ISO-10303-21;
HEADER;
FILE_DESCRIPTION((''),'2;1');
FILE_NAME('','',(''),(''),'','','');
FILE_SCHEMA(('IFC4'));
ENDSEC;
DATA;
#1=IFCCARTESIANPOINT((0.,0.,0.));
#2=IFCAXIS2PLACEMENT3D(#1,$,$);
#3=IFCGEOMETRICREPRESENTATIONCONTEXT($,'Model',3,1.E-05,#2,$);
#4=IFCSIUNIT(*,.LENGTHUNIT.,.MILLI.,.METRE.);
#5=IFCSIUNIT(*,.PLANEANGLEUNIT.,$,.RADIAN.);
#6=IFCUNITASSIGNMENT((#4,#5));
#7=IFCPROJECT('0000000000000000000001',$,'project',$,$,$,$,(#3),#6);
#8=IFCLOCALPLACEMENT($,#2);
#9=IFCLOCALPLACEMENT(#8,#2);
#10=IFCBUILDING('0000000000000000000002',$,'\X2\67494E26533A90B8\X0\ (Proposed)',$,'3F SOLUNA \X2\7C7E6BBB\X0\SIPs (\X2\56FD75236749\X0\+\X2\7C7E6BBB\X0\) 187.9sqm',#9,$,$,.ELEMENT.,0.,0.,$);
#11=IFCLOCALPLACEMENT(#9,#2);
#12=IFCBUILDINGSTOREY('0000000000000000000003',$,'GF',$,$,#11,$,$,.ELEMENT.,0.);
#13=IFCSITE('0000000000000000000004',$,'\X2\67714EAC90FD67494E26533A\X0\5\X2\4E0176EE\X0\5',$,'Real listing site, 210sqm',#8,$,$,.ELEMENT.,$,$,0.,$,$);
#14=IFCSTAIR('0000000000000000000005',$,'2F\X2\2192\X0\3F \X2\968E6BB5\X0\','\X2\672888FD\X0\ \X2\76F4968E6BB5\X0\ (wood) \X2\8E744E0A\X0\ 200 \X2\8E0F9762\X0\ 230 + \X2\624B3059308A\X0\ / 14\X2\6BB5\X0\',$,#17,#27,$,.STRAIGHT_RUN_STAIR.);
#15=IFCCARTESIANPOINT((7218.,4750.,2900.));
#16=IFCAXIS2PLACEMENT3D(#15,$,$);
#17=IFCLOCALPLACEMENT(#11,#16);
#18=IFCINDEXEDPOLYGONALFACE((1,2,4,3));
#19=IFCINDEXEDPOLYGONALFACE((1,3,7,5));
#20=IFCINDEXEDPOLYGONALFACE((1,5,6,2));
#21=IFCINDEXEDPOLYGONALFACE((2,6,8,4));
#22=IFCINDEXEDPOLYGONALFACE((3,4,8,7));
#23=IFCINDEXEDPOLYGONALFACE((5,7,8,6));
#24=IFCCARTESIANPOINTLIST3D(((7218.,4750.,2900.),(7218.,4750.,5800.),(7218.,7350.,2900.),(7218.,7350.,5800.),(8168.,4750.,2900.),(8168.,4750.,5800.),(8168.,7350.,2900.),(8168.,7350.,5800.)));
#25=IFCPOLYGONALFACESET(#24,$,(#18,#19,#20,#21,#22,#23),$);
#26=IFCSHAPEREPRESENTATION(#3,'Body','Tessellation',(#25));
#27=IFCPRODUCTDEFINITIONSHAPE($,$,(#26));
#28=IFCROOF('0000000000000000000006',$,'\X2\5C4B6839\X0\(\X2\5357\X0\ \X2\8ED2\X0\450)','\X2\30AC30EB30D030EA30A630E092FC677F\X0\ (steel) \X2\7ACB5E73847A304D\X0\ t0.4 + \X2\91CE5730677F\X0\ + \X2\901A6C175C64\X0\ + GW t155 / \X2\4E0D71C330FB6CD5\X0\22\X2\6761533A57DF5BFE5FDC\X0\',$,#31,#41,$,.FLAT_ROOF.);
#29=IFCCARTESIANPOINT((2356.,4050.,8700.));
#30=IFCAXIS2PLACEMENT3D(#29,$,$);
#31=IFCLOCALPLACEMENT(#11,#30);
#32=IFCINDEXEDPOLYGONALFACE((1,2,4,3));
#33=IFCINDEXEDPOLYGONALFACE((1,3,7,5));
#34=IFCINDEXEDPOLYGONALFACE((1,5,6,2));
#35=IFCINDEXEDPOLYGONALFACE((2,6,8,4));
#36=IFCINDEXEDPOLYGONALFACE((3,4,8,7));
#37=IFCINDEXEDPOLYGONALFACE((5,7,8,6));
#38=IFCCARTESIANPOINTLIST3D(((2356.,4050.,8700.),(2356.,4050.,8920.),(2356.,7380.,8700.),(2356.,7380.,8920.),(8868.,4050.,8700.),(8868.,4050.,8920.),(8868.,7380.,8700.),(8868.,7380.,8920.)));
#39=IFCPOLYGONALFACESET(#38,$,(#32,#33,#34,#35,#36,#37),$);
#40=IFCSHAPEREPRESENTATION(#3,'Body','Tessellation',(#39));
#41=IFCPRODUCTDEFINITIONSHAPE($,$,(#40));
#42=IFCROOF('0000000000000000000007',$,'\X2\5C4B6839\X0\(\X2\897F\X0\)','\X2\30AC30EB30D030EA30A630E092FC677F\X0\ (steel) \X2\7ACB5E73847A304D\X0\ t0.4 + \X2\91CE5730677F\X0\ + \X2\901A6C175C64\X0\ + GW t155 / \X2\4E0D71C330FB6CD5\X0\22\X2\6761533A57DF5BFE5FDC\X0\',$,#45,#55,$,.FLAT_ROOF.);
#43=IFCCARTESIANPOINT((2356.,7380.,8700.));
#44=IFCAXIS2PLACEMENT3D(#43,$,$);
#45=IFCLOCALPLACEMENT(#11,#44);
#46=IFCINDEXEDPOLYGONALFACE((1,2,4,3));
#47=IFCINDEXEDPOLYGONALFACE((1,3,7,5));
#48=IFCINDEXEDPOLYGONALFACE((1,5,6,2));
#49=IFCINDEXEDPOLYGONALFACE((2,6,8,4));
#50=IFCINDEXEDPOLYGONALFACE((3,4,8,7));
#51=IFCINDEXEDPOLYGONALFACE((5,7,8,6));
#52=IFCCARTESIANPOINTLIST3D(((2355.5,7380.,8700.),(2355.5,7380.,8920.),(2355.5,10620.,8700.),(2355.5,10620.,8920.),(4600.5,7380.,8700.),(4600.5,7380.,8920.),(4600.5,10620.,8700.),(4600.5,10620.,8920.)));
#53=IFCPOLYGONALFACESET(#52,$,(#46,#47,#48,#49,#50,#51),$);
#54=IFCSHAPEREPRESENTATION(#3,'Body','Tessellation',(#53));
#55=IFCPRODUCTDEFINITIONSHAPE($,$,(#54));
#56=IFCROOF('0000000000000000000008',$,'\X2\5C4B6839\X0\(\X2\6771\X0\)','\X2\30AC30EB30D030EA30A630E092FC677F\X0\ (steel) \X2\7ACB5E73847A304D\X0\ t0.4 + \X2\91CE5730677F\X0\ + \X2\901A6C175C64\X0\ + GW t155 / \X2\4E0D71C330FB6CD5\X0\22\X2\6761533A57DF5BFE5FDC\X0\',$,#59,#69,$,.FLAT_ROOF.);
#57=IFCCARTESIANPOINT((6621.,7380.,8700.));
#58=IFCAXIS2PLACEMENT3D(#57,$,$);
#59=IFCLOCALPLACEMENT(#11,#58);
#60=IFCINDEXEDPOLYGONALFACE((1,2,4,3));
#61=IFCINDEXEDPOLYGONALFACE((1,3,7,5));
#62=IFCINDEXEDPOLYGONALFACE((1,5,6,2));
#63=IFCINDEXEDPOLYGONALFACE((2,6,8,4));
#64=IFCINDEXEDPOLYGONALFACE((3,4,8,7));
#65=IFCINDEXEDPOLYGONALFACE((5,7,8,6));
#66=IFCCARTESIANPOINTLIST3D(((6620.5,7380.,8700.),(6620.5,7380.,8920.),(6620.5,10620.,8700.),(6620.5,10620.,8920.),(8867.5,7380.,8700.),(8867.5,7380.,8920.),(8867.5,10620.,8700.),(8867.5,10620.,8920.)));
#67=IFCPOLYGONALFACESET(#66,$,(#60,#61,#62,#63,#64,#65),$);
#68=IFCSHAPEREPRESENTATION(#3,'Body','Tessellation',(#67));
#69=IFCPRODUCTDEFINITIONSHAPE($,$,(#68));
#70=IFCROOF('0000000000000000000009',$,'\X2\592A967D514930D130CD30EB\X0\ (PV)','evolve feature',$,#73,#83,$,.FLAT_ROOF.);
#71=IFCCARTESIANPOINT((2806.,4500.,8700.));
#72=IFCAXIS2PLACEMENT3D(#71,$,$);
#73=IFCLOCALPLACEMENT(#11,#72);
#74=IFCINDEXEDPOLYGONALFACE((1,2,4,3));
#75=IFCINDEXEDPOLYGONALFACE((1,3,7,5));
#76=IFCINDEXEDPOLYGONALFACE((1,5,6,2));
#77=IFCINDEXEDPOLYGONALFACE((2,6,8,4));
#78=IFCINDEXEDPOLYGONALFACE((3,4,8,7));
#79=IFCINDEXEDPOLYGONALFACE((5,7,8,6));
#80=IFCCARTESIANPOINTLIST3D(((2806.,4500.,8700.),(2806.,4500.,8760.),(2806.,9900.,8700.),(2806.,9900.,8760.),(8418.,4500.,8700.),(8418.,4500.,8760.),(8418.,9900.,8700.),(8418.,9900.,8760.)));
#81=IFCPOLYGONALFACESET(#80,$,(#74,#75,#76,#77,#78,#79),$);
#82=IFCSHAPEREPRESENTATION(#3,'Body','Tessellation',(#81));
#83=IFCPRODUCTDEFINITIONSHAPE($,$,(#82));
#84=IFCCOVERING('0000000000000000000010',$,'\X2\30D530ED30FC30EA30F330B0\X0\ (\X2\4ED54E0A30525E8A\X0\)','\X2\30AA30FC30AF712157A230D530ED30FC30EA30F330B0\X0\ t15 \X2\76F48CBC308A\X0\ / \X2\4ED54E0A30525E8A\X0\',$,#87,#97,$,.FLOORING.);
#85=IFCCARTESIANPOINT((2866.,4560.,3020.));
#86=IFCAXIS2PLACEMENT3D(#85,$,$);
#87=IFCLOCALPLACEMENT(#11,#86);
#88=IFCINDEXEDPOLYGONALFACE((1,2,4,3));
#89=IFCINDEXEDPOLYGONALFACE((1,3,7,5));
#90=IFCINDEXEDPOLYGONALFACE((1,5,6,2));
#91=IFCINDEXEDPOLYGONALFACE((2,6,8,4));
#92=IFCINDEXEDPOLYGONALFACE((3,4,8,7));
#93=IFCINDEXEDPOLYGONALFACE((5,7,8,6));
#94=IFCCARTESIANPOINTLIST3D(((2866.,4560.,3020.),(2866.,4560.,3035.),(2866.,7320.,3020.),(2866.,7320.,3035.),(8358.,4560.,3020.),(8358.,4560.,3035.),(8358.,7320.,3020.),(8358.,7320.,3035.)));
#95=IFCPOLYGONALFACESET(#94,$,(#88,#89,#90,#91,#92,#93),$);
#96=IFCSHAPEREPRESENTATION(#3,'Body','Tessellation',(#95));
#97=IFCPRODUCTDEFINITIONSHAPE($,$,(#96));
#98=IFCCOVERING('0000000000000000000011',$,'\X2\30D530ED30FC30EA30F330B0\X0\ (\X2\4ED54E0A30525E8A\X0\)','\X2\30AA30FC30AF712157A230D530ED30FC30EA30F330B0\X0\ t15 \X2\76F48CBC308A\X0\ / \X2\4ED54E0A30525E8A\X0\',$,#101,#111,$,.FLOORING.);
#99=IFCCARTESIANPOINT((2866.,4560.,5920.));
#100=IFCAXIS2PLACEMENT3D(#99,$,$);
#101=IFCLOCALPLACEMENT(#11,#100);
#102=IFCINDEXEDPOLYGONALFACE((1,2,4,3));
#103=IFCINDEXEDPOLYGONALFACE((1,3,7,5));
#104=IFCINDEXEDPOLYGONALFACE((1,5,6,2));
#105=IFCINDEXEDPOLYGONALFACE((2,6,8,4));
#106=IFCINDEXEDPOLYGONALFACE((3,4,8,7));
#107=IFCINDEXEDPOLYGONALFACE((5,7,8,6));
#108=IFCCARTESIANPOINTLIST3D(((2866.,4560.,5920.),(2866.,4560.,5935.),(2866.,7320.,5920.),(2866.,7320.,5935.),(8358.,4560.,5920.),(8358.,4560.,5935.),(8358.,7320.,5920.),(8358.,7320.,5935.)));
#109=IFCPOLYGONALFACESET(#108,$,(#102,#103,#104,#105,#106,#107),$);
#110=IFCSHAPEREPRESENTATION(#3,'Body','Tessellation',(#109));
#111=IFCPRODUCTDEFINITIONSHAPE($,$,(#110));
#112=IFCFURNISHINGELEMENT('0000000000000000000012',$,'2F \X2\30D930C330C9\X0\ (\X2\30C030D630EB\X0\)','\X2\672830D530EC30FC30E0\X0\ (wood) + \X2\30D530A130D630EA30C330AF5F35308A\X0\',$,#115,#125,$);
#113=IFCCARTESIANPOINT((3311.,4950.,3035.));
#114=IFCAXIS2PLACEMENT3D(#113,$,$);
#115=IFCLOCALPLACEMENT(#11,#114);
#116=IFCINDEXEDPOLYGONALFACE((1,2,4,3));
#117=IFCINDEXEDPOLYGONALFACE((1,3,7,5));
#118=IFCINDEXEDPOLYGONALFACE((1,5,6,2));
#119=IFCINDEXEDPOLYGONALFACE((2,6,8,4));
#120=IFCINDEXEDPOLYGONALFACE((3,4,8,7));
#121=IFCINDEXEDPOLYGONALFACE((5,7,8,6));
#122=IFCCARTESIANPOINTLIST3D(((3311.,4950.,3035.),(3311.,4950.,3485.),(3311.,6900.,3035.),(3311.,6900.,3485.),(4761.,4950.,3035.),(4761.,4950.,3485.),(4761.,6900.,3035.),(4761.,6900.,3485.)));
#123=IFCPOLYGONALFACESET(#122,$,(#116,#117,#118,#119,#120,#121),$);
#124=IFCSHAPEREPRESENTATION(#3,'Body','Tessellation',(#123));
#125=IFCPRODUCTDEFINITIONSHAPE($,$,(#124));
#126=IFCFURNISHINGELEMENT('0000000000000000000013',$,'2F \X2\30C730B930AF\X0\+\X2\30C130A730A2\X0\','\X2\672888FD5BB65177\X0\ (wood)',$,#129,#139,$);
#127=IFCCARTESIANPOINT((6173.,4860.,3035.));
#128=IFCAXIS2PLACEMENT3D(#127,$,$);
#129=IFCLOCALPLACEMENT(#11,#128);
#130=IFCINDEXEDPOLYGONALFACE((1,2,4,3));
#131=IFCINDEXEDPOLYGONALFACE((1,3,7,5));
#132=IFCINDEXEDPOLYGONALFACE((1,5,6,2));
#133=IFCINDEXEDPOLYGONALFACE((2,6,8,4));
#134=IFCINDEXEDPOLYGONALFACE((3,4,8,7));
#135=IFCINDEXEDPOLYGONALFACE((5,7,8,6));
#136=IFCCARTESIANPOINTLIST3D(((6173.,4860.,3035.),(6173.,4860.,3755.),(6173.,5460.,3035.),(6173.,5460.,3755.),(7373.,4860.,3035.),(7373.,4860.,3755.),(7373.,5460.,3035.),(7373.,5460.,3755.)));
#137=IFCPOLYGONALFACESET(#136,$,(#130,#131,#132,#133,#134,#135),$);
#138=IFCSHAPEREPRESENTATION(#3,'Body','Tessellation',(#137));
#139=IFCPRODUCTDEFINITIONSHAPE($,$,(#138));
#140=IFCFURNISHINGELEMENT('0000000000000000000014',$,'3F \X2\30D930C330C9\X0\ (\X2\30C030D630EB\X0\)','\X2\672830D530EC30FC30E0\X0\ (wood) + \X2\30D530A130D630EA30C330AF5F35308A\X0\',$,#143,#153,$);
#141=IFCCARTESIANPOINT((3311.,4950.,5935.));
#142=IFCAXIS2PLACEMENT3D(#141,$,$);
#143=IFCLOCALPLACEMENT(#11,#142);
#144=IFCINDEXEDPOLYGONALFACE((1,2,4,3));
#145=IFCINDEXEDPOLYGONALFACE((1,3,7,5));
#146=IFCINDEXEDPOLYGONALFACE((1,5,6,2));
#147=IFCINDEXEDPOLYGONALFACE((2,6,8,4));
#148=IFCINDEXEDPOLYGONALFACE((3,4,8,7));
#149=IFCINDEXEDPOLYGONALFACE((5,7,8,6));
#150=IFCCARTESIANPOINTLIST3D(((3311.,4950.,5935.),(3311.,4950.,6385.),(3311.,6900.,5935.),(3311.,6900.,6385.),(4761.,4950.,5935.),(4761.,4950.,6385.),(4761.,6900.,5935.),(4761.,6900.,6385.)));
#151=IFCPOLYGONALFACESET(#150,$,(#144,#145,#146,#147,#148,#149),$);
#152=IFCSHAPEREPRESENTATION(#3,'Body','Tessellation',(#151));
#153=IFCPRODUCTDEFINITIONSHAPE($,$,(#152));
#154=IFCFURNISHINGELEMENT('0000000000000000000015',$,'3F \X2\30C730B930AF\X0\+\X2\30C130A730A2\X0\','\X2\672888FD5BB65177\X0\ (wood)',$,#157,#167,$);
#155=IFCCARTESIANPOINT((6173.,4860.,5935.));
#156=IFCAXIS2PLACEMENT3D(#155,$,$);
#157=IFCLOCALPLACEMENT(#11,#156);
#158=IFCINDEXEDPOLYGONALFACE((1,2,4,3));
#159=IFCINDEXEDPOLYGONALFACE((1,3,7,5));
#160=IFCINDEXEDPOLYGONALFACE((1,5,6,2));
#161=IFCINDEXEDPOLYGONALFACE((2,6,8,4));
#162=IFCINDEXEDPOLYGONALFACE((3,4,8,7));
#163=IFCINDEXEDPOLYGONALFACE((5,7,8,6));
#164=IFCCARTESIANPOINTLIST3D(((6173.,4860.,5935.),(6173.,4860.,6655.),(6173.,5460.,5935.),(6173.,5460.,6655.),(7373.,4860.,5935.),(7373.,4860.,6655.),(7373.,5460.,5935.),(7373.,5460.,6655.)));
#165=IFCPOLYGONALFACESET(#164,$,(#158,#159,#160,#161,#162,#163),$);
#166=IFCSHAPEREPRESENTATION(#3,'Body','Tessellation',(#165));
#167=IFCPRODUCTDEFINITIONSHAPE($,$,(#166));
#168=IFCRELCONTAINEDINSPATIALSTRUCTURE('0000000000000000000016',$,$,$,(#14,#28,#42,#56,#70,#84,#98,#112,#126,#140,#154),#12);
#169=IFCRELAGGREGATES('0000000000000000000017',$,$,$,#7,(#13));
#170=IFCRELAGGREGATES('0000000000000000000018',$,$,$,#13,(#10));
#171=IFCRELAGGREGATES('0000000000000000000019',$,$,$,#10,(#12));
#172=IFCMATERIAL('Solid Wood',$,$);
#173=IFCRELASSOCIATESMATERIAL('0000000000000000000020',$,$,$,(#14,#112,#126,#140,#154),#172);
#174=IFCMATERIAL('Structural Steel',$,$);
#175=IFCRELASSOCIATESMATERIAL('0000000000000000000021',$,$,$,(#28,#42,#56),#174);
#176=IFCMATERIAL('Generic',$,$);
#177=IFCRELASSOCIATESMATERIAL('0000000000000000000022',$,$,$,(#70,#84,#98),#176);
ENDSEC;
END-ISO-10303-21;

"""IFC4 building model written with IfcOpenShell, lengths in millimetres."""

from ifc_helpers import new_model, si_unit, frame, frame_2d, origin, place, context, project, spatial, rectangle, extrude, material, element, save


model = new_model("IFC4")

# Units and contexts
model_context = context("Model", 3, precision=1e-05, world=origin())
ifc_project = project(units=[si_unit("LENGTHUNIT", "METRE", prefix="MILLI"), si_unit("PLANEANGLEUNIT", "RADIAN")], contexts=[model_context])

# Site, building, storey
site_placement = place(None, origin())
site = spatial("IfcSite", under=ifc_project, at=site_placement, Name="東京都杉並区5丁目5", ObjectType="Real listing site, 210sqm", CompositionType="ELEMENT", RefElevation=0.0)
building_placement = place(site_placement, origin())
building = spatial("IfcBuilding", under=site, at=building_placement, Name="杉並区邸 (Proposed)", ObjectType="3F SOLUNA 籾殻SIPs (国産杉+籾殻) 187.9sqm", CompositionType="ELEMENT", ElevationOfRefHeight=0.0, ElevationOfTerrain=0.0)
storey_placement = place(building_placement, origin())
storey = spatial("IfcBuildingStorey", under=building, at=storey_placement, Name="GF", CompositionType="ELEMENT", Elevation=0.0)

# Shared definitions
ifc_material_1 = material(Name="Solid Wood")

# Stair
stair_placement = place(storey_placement, frame((7218.0, 4750.0, 2900.0)))
element("IfcStair", 1, at=stair_placement, inside=storey, material=ifc_material_1, Name="2F→3F 階段", Description="木製 直階段 (wood) 蹴上 200 踏面 230 + 手すり / 14段", PredefinedType="STRAIGHT_RUN_STAIR", context=model_context, shape_type="SweptSolid", body=[
    extrude(rectangle(XDim=950.0, YDim=2600.0, at=frame_2d((475.0, 1300.0))), frame((7218.0, 4750.0, 2900.0)), (0.0, 0.0, 1.0), 2900.0),
])

# Roofs
ifc_material_2 = material(Name="Structural Steel")
roof_1_placement = place(storey_placement, frame((2356.0, 4050.0, 8700.0)))
element("IfcRoof", 2, at=roof_1_placement, inside=storey, material=ifc_material_2, Name="屋根(南 軒450)", Description="ガルバリウム鋼板 (steel) 立平葺き t0.4 + 野地板 + 通気層 + GW t155 / 不燃・法22条区域対応", PredefinedType="FLAT_ROOF", context=model_context, shape_type="SweptSolid", body=[
    extrude(rectangle(XDim=6512.0, YDim=3330.0, at=frame_2d((3256.0, 1665.0))), frame((2356.0, 4050.0, 8700.0)), (0.0, 0.0, 1.0), 220.0),
])
roof_2_placement = place(storey_placement, frame((2356.0, 7380.0, 8700.0)))
element("IfcRoof", 3, at=roof_2_placement, inside=storey, material=ifc_material_2, Name="屋根(西)", Description="ガルバリウム鋼板 (steel) 立平葺き t0.4 + 野地板 + 通気層 + GW t155 / 不燃・法22条区域対応", PredefinedType="FLAT_ROOF", context=model_context, shape_type="SweptSolid", body=[
    extrude(rectangle(XDim=2245.0, YDim=3240.0, at=frame_2d((1122.0, 1620.0))), frame((2356.0, 7380.0, 8700.0)), (0.0, 0.0, 1.0), 220.0),
])
roof_3_placement = place(storey_placement, frame((6621.0, 7380.0, 8700.0)))
element("IfcRoof", 4, at=roof_3_placement, inside=storey, material=ifc_material_2, Name="屋根(東)", Description="ガルバリウム鋼板 (steel) 立平葺き t0.4 + 野地板 + 通気層 + GW t155 / 不燃・法22条区域対応", PredefinedType="FLAT_ROOF", context=model_context, shape_type="SweptSolid", body=[
    extrude(rectangle(XDim=2247.0, YDim=3240.0, at=frame_2d((1123.0, 1620.0))), frame((6621.0, 7380.0, 8700.0)), (0.0, 0.0, 1.0), 220.0),
])
ifc_material_3 = material(Name="Generic")
roof_4_placement = place(storey_placement, frame((2806.0, 4500.0, 8700.0)))
element("IfcRoof", 5, at=roof_4_placement, inside=storey, material=ifc_material_3, Name="太陽光パネル (PV)", Description="evolve feature", PredefinedType="FLAT_ROOF", context=model_context, shape_type="SweptSolid", body=[
    extrude(rectangle(XDim=5612.0, YDim=5400.0, at=frame_2d((2806.0, 2700.0))), frame((2806.0, 4500.0, 8700.0)), (0.0, 0.0, 1.0), 60.0),
])

# Coverings
covering_1_placement = place(storey_placement, frame((2866.0, 4560.0, 3020.0)))
element("IfcCovering", 6, at=covering_1_placement, inside=storey, material=ifc_material_3, Name="フローリング (仕上げ床)", Description="オーク無垢フローリング t15 直貼り / 仕上げ床", PredefinedType="FLOORING", context=model_context, shape_type="SweptSolid", body=[
    extrude(rectangle(XDim=5492.0, YDim=2760.0, at=frame_2d((2746.0, 1380.0))), frame((2866.0, 4560.0, 3020.0)), (0.0, 0.0, 1.0), 15.0),
])
covering_2_placement = place(storey_placement, frame((2866.0, 4560.0, 5920.0)))
element("IfcCovering", 7, at=covering_2_placement, inside=storey, material=ifc_material_3, Name="フローリング (仕上げ床)", Description="オーク無垢フローリング t15 直貼り / 仕上げ床", PredefinedType="FLOORING", context=model_context, shape_type="SweptSolid", body=[
    extrude(rectangle(XDim=5492.0, YDim=2760.0, at=frame_2d((2746.0, 1380.0))), frame((2866.0, 4560.0, 5920.0)), (0.0, 0.0, 1.0), 15.0),
])

# Furnishing elements
furnishing_1_placement = place(storey_placement, frame((3311.0, 4950.0, 3035.0)))
element("IfcFurnishingElement", 8, at=furnishing_1_placement, inside=storey, material=ifc_material_1, Name="2F ベッド (ダブル)", Description="木フレーム (wood) + ファブリック張り", context=model_context, shape_type="SweptSolid", body=[
    extrude(rectangle(XDim=1450.0, YDim=1950.0, at=frame_2d((725.0, 975.0))), frame((3311.0, 4950.0, 3035.0)), (0.0, 0.0, 1.0), 450.0),
])
furnishing_2_placement = place(storey_placement, frame((6173.0, 4860.0, 3035.0)))
element("IfcFurnishingElement", 9, at=furnishing_2_placement, inside=storey, material=ifc_material_1, Name="2F デスク+チェア", Description="木製家具 (wood)", context=model_context, shape_type="SweptSolid", body=[
    extrude(rectangle(XDim=1200.0, YDim=600.0, at=frame_2d((600.0, 300.0))), frame((6173.0, 4860.0, 3035.0)), (0.0, 0.0, 1.0), 720.0),
])
furnishing_3_placement = place(storey_placement, frame((3311.0, 4950.0, 5935.0)))
element("IfcFurnishingElement", 10, at=furnishing_3_placement, inside=storey, material=ifc_material_1, Name="3F ベッド (ダブル)", Description="木フレーム (wood) + ファブリック張り", context=model_context, shape_type="SweptSolid", body=[
    extrude(rectangle(XDim=1450.0, YDim=1950.0, at=frame_2d((725.0, 975.0))), frame((3311.0, 4950.0, 5935.0)), (0.0, 0.0, 1.0), 450.0),
])
furnishing_4_placement = place(storey_placement, frame((6173.0, 4860.0, 5935.0)))
element("IfcFurnishingElement", 11, at=furnishing_4_placement, inside=storey, material=ifc_material_1, Name="3F デスク+チェア", Description="木製家具 (wood)", context=model_context, shape_type="SweptSolid", body=[
    extrude(rectangle(XDim=1200.0, YDim=600.0, at=frame_2d((600.0, 300.0))), frame((6173.0, 4860.0, 5935.0)), (0.0, 0.0, 1.0), 720.0),
])

save(model, "model.ifc")
